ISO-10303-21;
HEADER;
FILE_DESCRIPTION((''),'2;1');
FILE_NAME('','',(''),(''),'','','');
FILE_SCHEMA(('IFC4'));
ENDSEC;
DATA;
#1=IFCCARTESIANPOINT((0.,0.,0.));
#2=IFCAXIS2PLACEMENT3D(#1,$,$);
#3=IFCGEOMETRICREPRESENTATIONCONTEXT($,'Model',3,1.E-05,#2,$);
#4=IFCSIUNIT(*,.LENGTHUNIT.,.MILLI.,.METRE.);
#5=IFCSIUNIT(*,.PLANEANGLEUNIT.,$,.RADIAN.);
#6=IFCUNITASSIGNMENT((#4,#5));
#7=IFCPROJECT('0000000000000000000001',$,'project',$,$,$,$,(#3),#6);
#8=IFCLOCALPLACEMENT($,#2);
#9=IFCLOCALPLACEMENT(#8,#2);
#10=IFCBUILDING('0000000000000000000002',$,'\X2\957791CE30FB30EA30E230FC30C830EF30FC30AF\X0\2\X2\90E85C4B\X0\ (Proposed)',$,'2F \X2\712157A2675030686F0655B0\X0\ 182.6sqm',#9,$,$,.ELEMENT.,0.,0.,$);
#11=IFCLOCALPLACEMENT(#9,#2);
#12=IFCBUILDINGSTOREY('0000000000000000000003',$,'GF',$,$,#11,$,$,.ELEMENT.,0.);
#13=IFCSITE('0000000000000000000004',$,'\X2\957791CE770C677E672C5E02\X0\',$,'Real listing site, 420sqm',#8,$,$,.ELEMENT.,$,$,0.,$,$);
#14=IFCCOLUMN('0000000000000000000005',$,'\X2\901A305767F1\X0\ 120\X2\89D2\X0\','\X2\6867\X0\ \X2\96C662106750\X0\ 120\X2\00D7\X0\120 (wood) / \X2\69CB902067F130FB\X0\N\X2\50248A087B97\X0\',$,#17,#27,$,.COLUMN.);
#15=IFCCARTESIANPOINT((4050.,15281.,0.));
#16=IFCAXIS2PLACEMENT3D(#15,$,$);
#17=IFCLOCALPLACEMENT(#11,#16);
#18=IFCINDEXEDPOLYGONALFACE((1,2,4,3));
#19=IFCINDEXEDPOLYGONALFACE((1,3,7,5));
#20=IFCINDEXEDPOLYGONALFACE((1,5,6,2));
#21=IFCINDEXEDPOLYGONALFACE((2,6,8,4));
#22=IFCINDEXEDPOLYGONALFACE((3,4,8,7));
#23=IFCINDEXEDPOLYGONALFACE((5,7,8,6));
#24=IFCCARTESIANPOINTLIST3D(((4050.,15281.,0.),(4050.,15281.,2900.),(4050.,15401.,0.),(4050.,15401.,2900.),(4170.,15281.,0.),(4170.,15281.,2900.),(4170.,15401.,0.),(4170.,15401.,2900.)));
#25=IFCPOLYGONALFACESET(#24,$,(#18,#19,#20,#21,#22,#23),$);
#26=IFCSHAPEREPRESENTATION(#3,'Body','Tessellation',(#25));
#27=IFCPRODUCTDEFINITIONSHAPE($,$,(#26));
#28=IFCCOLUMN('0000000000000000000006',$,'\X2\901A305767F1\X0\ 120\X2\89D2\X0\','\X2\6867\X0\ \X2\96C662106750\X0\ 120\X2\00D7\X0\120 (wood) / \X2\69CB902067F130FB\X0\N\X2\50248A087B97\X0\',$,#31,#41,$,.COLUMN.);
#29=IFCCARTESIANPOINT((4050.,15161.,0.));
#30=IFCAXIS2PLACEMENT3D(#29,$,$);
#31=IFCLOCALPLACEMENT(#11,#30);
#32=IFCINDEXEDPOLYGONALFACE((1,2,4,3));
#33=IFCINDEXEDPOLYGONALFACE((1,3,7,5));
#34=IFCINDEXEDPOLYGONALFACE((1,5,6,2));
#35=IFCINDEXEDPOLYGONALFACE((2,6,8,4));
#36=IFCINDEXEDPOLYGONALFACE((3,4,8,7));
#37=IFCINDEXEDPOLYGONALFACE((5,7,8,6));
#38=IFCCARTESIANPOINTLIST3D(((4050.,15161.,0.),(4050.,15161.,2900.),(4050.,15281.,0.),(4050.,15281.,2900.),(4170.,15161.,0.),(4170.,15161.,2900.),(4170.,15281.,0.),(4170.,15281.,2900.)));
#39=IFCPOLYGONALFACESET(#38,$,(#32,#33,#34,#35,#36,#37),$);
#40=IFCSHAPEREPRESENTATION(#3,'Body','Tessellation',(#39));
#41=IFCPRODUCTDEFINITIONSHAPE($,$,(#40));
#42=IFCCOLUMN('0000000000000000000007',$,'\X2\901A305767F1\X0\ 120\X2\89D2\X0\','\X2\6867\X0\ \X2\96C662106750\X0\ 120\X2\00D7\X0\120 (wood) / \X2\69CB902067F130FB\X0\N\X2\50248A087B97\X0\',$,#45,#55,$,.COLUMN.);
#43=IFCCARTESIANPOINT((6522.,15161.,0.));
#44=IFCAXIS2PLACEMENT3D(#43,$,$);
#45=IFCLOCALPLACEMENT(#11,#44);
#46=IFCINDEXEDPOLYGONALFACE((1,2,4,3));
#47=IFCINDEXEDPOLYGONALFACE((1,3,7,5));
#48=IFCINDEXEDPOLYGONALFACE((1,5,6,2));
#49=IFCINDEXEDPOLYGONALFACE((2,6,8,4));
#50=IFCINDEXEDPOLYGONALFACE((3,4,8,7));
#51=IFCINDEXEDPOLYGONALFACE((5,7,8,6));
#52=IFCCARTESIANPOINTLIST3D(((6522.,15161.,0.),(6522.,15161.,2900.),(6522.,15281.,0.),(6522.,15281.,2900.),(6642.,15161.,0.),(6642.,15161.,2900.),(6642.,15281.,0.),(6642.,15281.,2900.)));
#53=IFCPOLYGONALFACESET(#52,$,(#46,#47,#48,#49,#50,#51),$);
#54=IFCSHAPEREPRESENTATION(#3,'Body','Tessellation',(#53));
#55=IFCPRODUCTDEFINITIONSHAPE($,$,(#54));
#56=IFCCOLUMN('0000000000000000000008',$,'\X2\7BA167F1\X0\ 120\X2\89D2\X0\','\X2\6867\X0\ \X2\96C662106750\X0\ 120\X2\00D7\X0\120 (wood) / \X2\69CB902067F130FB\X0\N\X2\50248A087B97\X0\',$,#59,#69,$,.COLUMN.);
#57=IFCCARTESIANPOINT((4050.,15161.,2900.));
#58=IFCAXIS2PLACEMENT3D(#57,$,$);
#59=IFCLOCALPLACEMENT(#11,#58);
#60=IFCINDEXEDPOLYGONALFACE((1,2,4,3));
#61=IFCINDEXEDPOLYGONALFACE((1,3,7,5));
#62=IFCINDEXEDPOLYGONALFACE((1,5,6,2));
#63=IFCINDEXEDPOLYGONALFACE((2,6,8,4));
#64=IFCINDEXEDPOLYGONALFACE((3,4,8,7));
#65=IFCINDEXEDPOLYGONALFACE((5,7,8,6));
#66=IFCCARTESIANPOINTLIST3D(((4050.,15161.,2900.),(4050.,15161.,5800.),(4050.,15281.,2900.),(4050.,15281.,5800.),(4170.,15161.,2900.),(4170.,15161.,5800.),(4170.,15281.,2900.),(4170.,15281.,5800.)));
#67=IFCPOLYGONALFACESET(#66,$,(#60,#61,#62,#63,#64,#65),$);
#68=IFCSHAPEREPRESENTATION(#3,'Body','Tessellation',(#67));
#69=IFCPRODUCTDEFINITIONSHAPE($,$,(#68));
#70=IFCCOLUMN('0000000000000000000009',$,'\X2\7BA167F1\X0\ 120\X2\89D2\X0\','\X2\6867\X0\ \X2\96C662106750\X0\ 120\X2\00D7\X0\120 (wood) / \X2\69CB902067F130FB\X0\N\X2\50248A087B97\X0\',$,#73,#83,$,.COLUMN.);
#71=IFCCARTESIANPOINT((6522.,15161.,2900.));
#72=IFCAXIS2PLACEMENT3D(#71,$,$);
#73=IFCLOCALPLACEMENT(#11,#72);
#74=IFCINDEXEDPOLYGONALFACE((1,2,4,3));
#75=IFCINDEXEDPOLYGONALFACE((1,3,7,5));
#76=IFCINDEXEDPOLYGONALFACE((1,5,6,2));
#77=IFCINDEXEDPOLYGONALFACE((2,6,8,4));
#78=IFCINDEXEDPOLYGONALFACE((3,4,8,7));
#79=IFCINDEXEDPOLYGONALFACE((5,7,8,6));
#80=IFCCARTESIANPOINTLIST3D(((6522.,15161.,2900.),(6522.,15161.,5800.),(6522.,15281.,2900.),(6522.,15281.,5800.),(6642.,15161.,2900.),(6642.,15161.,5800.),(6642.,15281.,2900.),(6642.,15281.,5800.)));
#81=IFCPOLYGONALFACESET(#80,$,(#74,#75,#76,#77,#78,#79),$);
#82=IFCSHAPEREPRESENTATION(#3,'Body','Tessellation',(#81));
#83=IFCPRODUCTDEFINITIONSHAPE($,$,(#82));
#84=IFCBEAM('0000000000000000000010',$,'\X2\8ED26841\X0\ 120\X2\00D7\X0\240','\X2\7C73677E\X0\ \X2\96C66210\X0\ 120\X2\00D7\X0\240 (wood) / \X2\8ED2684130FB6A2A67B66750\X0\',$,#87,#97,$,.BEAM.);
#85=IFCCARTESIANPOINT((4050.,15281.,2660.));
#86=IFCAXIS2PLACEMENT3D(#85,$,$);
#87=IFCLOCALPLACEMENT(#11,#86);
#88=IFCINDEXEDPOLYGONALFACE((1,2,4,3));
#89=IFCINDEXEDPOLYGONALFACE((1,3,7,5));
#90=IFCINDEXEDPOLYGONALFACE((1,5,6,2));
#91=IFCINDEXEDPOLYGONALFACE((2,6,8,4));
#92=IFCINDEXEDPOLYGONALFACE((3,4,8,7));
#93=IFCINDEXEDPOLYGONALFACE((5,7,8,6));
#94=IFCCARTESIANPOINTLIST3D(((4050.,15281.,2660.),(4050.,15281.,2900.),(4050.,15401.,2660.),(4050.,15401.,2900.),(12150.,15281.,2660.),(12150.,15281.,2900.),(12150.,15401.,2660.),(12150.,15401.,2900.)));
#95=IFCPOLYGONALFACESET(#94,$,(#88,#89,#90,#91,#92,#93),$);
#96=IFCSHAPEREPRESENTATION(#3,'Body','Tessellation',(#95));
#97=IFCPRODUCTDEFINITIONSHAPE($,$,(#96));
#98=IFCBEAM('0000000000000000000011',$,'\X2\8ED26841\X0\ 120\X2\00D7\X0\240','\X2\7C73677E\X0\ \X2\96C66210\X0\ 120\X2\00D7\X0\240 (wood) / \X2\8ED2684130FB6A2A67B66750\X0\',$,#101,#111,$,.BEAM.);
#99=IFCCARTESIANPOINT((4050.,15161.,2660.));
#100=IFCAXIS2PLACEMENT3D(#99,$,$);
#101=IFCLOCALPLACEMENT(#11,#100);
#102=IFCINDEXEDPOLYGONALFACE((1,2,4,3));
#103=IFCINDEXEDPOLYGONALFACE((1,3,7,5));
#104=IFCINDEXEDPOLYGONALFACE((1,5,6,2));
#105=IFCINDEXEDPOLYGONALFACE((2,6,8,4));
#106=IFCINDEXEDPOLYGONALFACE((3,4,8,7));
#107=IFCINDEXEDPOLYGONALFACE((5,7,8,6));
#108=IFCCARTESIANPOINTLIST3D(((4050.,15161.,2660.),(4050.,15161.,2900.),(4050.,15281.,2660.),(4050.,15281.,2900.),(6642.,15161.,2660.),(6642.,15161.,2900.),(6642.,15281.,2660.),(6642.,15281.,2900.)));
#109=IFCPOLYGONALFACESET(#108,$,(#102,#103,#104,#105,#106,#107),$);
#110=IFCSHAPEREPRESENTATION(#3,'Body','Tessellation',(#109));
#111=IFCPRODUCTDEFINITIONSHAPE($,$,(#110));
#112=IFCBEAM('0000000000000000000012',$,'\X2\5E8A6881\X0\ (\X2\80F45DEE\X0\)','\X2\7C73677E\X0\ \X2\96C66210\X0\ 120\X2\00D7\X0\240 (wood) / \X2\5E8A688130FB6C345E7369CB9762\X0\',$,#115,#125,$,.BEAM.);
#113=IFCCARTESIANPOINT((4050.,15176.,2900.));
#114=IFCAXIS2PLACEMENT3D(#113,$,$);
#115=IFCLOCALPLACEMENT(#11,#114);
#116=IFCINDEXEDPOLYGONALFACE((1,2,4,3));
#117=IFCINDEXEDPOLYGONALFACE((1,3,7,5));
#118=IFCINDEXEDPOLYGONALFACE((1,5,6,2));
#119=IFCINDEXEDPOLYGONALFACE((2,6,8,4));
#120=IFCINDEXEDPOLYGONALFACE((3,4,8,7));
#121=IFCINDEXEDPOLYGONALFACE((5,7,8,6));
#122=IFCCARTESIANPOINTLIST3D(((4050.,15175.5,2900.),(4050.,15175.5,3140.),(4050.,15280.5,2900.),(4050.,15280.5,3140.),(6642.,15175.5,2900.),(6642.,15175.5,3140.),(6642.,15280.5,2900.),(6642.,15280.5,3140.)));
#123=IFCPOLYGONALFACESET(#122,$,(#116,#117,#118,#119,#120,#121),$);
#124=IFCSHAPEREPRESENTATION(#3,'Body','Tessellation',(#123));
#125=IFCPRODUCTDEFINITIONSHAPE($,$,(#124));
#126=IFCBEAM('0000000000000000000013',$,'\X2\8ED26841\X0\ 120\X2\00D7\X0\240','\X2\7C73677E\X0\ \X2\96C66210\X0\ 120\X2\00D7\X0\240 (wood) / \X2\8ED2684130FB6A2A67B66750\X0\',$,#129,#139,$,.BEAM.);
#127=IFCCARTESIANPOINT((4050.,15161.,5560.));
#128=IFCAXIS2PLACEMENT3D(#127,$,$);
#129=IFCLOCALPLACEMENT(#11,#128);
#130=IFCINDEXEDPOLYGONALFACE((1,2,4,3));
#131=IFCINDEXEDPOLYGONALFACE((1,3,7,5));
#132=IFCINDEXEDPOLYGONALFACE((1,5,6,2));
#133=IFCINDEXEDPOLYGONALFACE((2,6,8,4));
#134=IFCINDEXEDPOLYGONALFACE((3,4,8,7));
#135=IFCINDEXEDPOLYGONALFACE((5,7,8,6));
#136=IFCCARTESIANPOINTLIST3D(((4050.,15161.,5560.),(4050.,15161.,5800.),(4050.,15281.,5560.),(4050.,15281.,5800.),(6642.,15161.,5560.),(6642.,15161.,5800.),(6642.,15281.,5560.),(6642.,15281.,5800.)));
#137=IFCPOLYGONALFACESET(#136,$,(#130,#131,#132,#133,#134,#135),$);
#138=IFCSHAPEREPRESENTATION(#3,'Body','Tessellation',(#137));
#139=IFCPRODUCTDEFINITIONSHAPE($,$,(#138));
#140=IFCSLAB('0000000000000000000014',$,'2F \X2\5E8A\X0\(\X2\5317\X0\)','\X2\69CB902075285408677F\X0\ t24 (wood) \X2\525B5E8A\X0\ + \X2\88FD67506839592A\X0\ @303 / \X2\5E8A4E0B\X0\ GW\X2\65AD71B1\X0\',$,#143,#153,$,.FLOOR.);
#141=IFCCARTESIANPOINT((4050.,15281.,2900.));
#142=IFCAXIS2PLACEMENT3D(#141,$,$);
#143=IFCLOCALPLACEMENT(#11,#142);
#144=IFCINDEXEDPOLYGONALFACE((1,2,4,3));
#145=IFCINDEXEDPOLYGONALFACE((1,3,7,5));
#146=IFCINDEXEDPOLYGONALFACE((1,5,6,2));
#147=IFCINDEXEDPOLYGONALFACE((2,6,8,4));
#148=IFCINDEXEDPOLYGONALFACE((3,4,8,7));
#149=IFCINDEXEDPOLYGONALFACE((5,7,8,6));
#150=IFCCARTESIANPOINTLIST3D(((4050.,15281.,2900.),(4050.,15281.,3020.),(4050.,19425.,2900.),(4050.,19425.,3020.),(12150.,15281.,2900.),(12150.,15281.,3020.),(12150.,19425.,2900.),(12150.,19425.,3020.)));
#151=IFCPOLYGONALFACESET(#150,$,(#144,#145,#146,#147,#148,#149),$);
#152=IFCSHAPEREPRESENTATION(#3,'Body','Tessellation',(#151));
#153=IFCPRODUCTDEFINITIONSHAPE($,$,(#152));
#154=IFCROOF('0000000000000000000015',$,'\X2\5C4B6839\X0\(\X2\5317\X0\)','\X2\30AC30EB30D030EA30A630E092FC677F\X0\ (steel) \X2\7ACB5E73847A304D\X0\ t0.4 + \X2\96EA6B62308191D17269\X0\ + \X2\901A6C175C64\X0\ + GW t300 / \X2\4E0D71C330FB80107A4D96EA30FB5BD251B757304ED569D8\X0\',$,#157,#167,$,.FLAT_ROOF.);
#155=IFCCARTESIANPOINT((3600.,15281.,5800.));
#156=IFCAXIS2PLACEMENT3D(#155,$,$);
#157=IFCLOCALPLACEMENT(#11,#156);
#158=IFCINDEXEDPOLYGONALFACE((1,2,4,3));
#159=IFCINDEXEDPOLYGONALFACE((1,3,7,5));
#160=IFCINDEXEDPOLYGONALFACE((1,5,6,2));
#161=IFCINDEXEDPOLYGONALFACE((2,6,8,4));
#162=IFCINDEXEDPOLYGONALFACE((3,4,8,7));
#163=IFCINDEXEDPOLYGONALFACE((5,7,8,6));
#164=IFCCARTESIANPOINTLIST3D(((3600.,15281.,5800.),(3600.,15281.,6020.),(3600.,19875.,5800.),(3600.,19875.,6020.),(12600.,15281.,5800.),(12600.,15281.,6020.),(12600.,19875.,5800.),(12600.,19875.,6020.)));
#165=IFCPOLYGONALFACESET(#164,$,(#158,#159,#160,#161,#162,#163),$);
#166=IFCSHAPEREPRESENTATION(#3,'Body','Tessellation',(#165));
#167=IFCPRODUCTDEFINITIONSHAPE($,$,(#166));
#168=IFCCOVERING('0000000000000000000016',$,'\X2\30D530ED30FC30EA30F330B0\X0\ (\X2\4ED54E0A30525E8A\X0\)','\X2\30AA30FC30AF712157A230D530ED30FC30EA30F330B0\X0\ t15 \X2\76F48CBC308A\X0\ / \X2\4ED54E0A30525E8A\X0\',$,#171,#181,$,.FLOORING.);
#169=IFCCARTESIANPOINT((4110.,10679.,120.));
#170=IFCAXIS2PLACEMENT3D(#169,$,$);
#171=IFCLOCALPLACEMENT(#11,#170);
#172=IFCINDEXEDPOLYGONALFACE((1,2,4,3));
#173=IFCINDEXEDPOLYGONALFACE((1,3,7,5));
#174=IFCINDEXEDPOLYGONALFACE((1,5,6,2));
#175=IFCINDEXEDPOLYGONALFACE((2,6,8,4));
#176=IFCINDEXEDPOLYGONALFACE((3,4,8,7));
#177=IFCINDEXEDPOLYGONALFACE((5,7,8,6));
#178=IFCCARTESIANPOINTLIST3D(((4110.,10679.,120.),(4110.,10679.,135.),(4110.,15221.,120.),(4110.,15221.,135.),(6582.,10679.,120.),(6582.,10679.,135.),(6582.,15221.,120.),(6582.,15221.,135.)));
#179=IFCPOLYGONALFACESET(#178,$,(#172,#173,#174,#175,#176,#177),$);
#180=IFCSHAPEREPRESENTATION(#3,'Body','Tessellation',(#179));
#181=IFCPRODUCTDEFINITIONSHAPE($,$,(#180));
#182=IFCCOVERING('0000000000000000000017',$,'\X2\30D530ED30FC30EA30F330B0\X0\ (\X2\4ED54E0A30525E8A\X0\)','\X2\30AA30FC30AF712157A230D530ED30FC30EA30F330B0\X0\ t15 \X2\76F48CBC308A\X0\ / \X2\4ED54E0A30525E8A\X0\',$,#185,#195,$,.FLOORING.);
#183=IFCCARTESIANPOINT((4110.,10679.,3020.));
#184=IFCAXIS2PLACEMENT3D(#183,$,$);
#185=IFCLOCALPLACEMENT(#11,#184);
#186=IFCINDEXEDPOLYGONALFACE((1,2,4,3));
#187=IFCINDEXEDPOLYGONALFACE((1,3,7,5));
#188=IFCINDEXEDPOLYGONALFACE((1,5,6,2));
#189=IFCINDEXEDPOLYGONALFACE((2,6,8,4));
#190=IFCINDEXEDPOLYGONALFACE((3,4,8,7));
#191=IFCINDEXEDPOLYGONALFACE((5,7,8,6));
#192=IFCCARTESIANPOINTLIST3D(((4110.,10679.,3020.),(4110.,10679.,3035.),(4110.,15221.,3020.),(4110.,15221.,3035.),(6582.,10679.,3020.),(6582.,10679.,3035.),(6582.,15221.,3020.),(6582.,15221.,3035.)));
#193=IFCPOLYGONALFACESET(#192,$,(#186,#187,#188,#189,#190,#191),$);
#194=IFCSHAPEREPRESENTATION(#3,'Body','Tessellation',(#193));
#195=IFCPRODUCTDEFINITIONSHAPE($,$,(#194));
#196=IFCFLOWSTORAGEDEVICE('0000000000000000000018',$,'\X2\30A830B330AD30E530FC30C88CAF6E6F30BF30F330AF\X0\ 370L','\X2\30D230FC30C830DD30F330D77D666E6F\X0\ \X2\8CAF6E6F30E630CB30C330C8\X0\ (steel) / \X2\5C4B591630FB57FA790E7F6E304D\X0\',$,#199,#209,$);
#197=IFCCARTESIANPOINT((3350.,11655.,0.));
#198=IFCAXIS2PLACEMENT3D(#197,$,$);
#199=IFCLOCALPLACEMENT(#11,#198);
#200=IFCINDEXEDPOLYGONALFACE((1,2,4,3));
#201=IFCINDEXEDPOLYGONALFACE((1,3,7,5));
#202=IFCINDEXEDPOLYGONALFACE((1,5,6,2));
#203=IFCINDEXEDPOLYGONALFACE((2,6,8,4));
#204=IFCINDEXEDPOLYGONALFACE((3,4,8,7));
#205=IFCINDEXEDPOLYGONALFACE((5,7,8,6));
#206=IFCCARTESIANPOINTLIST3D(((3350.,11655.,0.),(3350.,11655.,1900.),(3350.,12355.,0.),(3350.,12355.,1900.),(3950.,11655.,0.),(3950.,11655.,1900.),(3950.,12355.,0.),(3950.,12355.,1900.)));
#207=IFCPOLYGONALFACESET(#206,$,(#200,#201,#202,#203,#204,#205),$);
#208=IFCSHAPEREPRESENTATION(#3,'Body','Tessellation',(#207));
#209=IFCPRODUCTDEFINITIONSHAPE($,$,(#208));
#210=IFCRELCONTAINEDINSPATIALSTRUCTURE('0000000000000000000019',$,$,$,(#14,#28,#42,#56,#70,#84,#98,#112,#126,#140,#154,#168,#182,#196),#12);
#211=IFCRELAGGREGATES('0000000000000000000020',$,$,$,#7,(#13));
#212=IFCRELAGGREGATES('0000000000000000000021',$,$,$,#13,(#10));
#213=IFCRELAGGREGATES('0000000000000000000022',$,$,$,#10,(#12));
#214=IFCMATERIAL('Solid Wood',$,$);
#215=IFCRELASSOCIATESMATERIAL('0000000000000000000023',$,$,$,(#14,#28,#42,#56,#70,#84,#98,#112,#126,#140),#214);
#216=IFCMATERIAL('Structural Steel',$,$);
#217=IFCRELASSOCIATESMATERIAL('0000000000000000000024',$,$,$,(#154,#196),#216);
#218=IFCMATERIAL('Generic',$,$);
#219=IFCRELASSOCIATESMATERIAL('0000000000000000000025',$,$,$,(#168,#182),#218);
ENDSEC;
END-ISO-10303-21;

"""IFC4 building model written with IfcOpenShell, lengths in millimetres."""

from ifc_helpers import new_model, si_unit, frame, frame_2d, origin, place, context, project, spatial, rectangle, extrude, material, element, save


model = new_model("IFC4")

# Units and contexts
model_context = context("Model", 3, precision=1e-05, world=origin())
ifc_project = project(units=[si_unit("LENGTHUNIT", "METRE", prefix="MILLI"), si_unit("PLANEANGLEUNIT", "RADIAN")], contexts=[model_context])

# Site, building, storey
site_placement = place(None, origin())
site = spatial("IfcSite", under=ifc_project, at=site_placement, Name="長野県松本市", ObjectType="Real listing site, 420sqm", CompositionType="ELEMENT", RefElevation=0.0)
building_placement = place(site_placement, origin())
building = spatial("IfcBuilding", under=site, at=building_placement, Name="長野・リモートワーク2部屋 (Proposed)", ObjectType="2F 無垢材と漆喰 182.6sqm", CompositionType="ELEMENT", ElevationOfRefHeight=0.0, ElevationOfTerrain=0.0)
storey_placement = place(building_placement, origin())
storey = spatial("IfcBuildingStorey", under=building, at=storey_placement, Name="GF", CompositionType="ELEMENT", Elevation=0.0)

# Columns
ifc_material_1 = material(Name="Solid Wood")
column_1_placement = place(storey_placement, frame((4050.0, 15281.0, 0.0)))
element("IfcColumn", 1, at=column_1_placement, inside=storey, material=ifc_material_1, Name="通し柱 120角", Description="桧 集成材 120×120 (wood) / 構造柱・N値計算", PredefinedType="COLUMN", context=model_context, shape_type="SweptSolid", body=[
    extrude(rectangle(XDim=120.0, YDim=120.0, at=frame_2d((60.0, 60.0))), frame((4050.0, 15281.0, 0.0)), (0.0, 0.0, 1.0), 2900.0),
])
column_2_placement = place(storey_placement, frame((4050.0, 15161.0, 0.0)))
element("IfcColumn", 2, at=column_2_placement, inside=storey, material=ifc_material_1, Name="通し柱 120角", Description="桧 集成材 120×120 (wood) / 構造柱・N値計算", PredefinedType="COLUMN", context=model_context, shape_type="SweptSolid", body=[
    extrude(rectangle(XDim=120.0, YDim=120.0, at=frame_2d((60.0, 60.0))), frame((4050.0, 15161.0, 0.0)), (0.0, 0.0, 1.0), 2900.0),
])
column_3_placement = place(storey_placement, frame((6522.0, 15161.0, 0.0)))
element("IfcColumn", 3, at=column_3_placement, inside=storey, material=ifc_material_1, Name="通し柱 120角", Description="桧 集成材 120×120 (wood) / 構造柱・N値計算", PredefinedType="COLUMN", context=model_context, shape_type="SweptSolid", body=[
    extrude(rectangle(XDim=120.0, YDim=120.0, at=frame_2d((60.0, 60.0))), frame((6522.0, 15161.0, 0.0)), (0.0, 0.0, 1.0), 2900.0),
])
column_4_placement = place(storey_placement, frame((4050.0, 15161.0, 2900.0)))
element("IfcColumn", 4, at=column_4_placement, inside=storey, material=ifc_material_1, Name="管柱 120角", Description="桧 集成材 120×120 (wood) / 構造柱・N値計算", PredefinedType="COLUMN", context=model_context, shape_type="SweptSolid", body=[
    extrude(rectangle(XDim=120.0, YDim=120.0, at=frame_2d((60.0, 60.0))), frame((4050.0, 15161.0, 2900.0)), (0.0, 0.0, 1.0), 2900.0),
])
column_5_placement = place(storey_placement, frame((6522.0, 15161.0, 2900.0)))
element("IfcColumn", 5, at=column_5_placement, inside=storey, material=ifc_material_1, Name="管柱 120角", Description="桧 集成材 120×120 (wood) / 構造柱・N値計算", PredefinedType="COLUMN", context=model_context, shape_type="SweptSolid", body=[
    extrude(rectangle(XDim=120.0, YDim=120.0, at=frame_2d((60.0, 60.0))), frame((6522.0, 15161.0, 2900.0)), (0.0, 0.0, 1.0), 2900.0),
])

# Beams
beam_1_placement = place(storey_placement, frame((4050.0, 15281.0, 2660.0)))
element("IfcBeam", 6, at=beam_1_placement, inside=storey, material=ifc_material_1, Name="軒桁 120×240", Description="米松 集成 120×240 (wood) / 軒桁・横架材", PredefinedType="BEAM", context=model_context, shape_type="SweptSolid", body=[
    extrude(rectangle(XDim=8100.0, YDim=120.0, at=frame_2d((4050.0, 60.0))), frame((4050.0, 15281.0, 2660.0)), (0.0, 0.0, 1.0), 240.0),
])
beam_2_placement = place(storey_placement, frame((4050.0, 15161.0, 2660.0)))
element("IfcBeam", 7, at=beam_2_placement, inside=storey, material=ifc_material_1, Name="軒桁 120×240", Description="米松 集成 120×240 (wood) / 軒桁・横架材", PredefinedType="BEAM", context=model_context, shape_type="SweptSolid", body=[
    extrude(rectangle(XDim=2592.0, YDim=120.0, at=frame_2d((1296.0, 60.0))), frame((4050.0, 15161.0, 2660.0)), (0.0, 0.0, 1.0), 240.0),
])
beam_3_placement = place(storey_placement, frame((4050.0, 15176.0, 2900.0)))
element("IfcBeam", 8, at=beam_3_placement, inside=storey, material=ifc_material_1, Name="床梁 (胴差)", Description="米松 集成 120×240 (wood) / 床梁・水平構面", PredefinedType="BEAM", context=model_context, shape_type="SweptSolid", body=[
    extrude(rectangle(XDim=2592.0, YDim=105.0, at=frame_2d((1296.0, 52.0))), frame((4050.0, 15176.0, 2900.0)), (0.0, 0.0, 1.0), 240.0),
])
beam_4_placement = place(storey_placement, frame((4050.0, 15161.0, 5560.0)))
element("IfcBeam", 9, at=beam_4_placement, inside=storey, material=ifc_material_1, Name="軒桁 120×240", Description="米松 集成 120×240 (wood) / 軒桁・横架材", PredefinedType="BEAM", context=model_context, shape_type="SweptSolid", body=[
    extrude(rectangle(XDim=2592.0, YDim=120.0, at=frame_2d((1296.0, 60.0))), frame((4050.0, 15161.0, 5560.0)), (0.0, 0.0, 1.0), 240.0),
])

# Slab
slab_1_placement = place(storey_placement, frame((4050.0, 15281.0, 2900.0)))
element("IfcSlab", 10, at=slab_1_placement, inside=storey, material=ifc_material_1, Name="2F 床(北)", Description="構造用合板 t24 (wood) 剛床 + 製材根太 @303 / 床下 GW断熱", PredefinedType="FLOOR", context=model_context, shape_type="SweptSolid", body=[
    extrude(rectangle(XDim=8100.0, YDim=4144.0, at=frame_2d((4050.0, 2072.0))), frame((4050.0, 15281.0, 2900.0)), (0.0, 0.0, 1.0), 120.0),
])

# Roof
ifc_material_2 = material(Name="Structural Steel")
for number, where, name in (
    (11, (3600.0, 15281.0, 5800.0), "屋根(北)"),
):
    element("IfcRoof", number, at=place(storey_placement, frame(where)), inside=storey, material=ifc_material_2, Name=name, Description="ガルバリウム鋼板 (steel) 立平葺き t0.4 + 雪止め金物 + 通気層 + GW t300 / 不燃・耐積雪・寒冷地仕様", PredefinedType="FLAT_ROOF", context=model_context, shape_type="SweptSolid", body=[
        extrude(rectangle(XDim=9000.0, YDim=4594.0, at=frame_2d((4500.0, 2297.0))), frame((3600.0, 15281.0, 5800.0)), (0.0, 0.0, 1.0), 220.0),
    ])

# Coverings
ifc_material_3 = material(Name="Generic")
covering_1_placement = place(storey_placement, frame((4110.0, 10679.0, 120.0)))
element("IfcCovering", 12, at=covering_1_placement, inside=storey, material=ifc_material_3, Name="フローリング (仕上げ床)", Description="オーク無垢フローリング t15 直貼り / 仕上げ床", PredefinedType="FLOORING", context=model_context, shape_type="SweptSolid", body=[
    extrude(rectangle(XDim=2472.0, YDim=4542.0, at=frame_2d((1236.0, 2271.0))), frame((4110.0, 10679.0, 120.0)), (0.0, 0.0, 1.0), 15.0),
])
covering_2_placement = place(storey_placement, frame((4110.0, 10679.0, 3020.0)))
element("IfcCovering", 13, at=covering_2_placement, inside=storey, material=ifc_material_3, Name="フローリング (仕上げ床)", Description="オーク無垢フローリング t15 直貼り / 仕上げ床", PredefinedType="FLOORING", context=model_context, shape_type="SweptSolid", body=[
    extrude(rectangle(XDim=2472.0, YDim=4542.0, at=frame_2d((1236.0, 2271.0))), frame((4110.0, 10679.0, 3020.0)), (0.0, 0.0, 1.0), 15.0),
])

# Flow storage device
flow_storage_device_placement = place(storey_placement, frame((3350.0, 11655.0, 0.0)))
element("IfcFlowStorageDevice", 14, at=flow_storage_device_placement, inside=storey, material=ifc_material_2, Name="エコキュート貯湯タンク 370L", Description="ヒートポンプ給湯 貯湯ユニット (steel) / 屋外・基礎置き", context=model_context, shape_type="SweptSolid", body=[
    extrude(rectangle(XDim=600.0, YDim=700.0, at=frame_2d((300.0, 350.0))), frame((3350.0, 11655.0, 0.0)), (0.0, 0.0, 1.0), 1900.0),
])

save(model, "model.ifc")
